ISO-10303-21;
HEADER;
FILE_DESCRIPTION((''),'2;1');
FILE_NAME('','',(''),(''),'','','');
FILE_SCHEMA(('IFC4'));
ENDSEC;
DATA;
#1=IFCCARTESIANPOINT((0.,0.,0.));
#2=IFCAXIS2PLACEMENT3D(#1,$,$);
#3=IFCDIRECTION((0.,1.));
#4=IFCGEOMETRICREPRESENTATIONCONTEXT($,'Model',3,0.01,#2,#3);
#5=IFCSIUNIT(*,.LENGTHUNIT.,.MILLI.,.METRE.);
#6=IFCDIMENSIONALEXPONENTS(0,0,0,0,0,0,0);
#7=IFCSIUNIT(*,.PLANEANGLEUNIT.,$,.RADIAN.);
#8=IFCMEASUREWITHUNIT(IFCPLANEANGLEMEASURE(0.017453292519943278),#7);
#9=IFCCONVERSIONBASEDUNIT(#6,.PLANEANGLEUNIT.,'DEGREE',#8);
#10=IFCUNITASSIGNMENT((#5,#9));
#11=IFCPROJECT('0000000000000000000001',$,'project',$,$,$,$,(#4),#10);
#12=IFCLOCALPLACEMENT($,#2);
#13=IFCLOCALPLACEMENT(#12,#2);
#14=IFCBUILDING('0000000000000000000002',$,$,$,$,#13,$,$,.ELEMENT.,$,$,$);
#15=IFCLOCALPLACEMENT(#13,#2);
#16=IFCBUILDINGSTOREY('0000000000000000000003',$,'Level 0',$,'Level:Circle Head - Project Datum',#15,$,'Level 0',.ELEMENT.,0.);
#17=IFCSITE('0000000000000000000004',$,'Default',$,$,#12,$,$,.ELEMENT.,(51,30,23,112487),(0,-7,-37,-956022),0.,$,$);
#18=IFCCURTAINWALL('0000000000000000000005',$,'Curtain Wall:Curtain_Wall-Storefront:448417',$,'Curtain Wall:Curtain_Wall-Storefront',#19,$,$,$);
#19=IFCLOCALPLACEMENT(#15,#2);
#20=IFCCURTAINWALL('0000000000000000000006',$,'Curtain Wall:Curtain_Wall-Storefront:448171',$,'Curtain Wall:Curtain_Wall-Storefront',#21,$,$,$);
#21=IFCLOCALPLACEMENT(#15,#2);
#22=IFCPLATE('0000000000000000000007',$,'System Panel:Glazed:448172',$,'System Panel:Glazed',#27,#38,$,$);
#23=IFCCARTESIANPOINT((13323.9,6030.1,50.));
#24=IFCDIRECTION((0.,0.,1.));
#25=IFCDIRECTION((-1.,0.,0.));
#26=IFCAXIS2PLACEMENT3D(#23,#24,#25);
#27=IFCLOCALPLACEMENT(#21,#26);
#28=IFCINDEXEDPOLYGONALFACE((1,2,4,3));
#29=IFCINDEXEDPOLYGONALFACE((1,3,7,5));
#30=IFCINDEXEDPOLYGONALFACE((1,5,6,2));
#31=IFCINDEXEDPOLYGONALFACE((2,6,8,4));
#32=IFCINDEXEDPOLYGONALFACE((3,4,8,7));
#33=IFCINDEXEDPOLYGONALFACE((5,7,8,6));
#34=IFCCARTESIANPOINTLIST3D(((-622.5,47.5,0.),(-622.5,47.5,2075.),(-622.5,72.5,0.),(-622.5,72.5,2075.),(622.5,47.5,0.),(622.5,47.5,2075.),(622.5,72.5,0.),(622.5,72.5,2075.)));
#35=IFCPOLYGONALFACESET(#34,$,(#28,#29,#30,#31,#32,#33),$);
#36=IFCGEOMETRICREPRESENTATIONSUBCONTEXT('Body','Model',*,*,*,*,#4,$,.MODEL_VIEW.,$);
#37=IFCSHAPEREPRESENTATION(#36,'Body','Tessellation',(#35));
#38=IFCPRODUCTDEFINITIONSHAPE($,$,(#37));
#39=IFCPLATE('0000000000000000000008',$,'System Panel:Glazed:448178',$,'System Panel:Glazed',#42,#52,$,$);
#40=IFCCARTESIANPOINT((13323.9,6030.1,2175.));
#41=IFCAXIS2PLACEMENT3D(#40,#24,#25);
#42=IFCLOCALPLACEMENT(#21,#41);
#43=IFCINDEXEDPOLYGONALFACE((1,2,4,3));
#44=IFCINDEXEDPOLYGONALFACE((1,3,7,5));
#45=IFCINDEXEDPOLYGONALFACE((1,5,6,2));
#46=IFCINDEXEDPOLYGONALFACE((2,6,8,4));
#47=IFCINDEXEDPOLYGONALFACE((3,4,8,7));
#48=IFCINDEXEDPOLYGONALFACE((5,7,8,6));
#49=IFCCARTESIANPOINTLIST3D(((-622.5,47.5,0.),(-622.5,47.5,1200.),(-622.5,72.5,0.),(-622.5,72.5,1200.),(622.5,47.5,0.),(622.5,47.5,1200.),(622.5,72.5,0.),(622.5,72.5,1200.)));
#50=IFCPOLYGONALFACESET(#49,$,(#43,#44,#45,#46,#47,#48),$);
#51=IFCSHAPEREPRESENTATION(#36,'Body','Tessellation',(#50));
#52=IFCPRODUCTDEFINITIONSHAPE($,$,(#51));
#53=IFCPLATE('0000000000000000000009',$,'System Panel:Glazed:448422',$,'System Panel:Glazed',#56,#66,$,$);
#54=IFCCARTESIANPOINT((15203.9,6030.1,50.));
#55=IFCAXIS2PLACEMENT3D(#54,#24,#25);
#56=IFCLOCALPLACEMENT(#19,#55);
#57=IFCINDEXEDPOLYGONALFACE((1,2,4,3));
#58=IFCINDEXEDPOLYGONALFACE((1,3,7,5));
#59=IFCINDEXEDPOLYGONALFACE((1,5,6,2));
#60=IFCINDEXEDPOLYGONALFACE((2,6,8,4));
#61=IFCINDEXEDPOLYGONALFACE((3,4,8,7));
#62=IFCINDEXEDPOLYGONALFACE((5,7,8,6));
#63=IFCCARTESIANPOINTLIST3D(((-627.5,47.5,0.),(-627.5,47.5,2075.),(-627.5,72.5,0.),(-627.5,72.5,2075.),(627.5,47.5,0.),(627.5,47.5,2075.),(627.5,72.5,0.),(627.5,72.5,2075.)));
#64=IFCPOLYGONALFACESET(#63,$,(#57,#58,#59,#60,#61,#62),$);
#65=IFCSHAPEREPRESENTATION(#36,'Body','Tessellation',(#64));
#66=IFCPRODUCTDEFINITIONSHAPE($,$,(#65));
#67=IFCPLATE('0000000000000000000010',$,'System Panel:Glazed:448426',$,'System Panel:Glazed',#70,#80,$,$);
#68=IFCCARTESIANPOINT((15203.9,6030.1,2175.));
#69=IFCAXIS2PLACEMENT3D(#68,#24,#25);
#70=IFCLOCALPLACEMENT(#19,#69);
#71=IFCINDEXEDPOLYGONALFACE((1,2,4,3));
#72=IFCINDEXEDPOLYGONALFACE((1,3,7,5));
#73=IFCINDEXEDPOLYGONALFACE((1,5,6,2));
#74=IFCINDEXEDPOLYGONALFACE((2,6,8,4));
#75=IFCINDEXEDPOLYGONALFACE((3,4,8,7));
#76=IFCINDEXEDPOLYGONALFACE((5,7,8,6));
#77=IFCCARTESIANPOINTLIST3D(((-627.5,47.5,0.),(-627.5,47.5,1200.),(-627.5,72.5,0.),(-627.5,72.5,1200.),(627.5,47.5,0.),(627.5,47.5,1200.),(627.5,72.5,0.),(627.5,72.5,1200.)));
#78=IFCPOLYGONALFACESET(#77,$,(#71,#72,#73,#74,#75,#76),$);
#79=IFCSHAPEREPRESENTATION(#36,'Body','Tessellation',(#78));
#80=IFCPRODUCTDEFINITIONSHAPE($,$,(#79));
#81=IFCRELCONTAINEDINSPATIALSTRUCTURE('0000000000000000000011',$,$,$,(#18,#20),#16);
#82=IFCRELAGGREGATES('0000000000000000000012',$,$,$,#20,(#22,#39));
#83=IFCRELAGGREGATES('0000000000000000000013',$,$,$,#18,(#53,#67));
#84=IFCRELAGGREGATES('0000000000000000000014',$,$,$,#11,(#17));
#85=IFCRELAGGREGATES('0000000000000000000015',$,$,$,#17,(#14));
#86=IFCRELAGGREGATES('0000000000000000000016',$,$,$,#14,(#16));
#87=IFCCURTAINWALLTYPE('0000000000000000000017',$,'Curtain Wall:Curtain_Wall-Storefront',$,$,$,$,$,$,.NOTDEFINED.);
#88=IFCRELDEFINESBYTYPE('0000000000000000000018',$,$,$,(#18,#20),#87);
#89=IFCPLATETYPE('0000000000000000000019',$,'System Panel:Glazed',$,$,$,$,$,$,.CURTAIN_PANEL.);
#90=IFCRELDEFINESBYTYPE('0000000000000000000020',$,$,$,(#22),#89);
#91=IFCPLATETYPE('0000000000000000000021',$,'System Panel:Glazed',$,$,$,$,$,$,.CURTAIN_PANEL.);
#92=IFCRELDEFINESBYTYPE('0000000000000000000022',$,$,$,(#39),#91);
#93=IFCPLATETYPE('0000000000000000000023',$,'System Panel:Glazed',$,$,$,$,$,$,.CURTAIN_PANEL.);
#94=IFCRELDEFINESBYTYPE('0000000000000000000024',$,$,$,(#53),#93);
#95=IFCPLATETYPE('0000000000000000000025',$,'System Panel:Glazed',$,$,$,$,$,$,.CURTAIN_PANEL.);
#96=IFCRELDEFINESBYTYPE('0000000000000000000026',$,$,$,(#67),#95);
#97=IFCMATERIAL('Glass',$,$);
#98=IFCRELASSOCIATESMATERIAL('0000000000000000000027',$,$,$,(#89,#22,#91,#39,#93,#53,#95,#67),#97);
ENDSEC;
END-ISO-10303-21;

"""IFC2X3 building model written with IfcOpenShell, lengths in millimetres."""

from ifc_helpers import new_model, entity, si_unit, converted_unit, direction, frame, origin, origin_2d_with_axis, place, context, subcontext, project, spatial, rectangle, extrude, source, transform, mapped, material, type_object, type_shapes, element, aggregate, save


model = new_model("IFC2X3")

# Units and contexts
model_context = context("Model", 3, precision=0.01, world=origin(), true_north=direction((0.0, 1.0)))
body_context = subcontext(model_context, "Body", "Model", "MODEL_VIEW")
ifc_project = project(units=[si_unit("LENGTHUNIT", "METRE", prefix="MILLI"), converted_unit("PLANEANGLEUNIT", "DEGREE", entity("IfcPlaneAngleMeasure", 0.017453292519943278), si_unit("PLANEANGLEUNIT", "RADIAN"), dimensions=[0, 0, 0, 0, 0, 0, 0])], contexts=[model_context])

# Site, building, storey
site_placement = place(None, origin())
site = spatial("IfcSite", under=ifc_project, at=site_placement, Name="Default", CompositionType="ELEMENT", RefLatitude=(51, 30, 23, 112487), RefLongitude=(0, -7, -37, -956022), RefElevation=0.0)
building_placement = place(site_placement, origin())
building = spatial("IfcBuilding", under=site, at=building_placement, CompositionType="ELEMENT")
storey_placement = place(building_placement, origin())
storey = spatial("IfcBuildingStorey", under=building, at=storey_placement, Name="Level 0", ObjectType="Level:Circle Head - Project Datum", LongName="Level 0", CompositionType="ELEMENT", Elevation=0.0)

# Curtain walls
curtain_wall_type = type_object("IfcCurtainWallType", Name="Curtain Wall:Curtain_Wall-Storefront", PredefinedType="NOTDEFINED")
curtain_wall_1_placement = place(storey_placement, origin())
curtain_wall_1 = element("IfcCurtainWall", 1, at=curtain_wall_1_placement, inside=storey, type_object=curtain_wall_type, Name="Curtain Wall:Curtain_Wall-Storefront:448417", ObjectType="Curtain Wall:Curtain_Wall-Storefront")
curtain_wall_2_placement = place(storey_placement, origin())
curtain_wall_2 = element("IfcCurtainWall", 2, at=curtain_wall_2_placement, inside=storey, type_object=curtain_wall_type, Name="Curtain Wall:Curtain_Wall-Storefront:448171", ObjectType="Curtain Wall:Curtain_Wall-Storefront")

# Plates
ifc_material_1 = material(Name="Glass")
plate_type_1 = type_object("IfcPlateType", Name="System Panel:Glazed", PredefinedType="CURTAIN_PANEL", material=ifc_material_1)
shared_shape_1 = source(origin(), body_context, "Body", "SweptSolid", [
    extrude(rectangle(XDim=25.0, YDim=1245.0, at=origin_2d_with_axis()), frame((0.0, 60.0, 0.0), z_axis=(0.0, 0.0, 1.0), x_axis=(0.0, 1.0, 0.0)), (0.0, 0.0, 1.0), 2075.0),
])
type_shapes(plate_type_1, [shared_shape_1])
plate_1_placement = place(curtain_wall_2_placement, frame((13323.9, 6030.1, 50.0), z_axis=(0.0, 0.0, 1.0), x_axis=(-1.0, 0.0, 0.0)))
plate_1 = element("IfcPlate", 3, at=plate_1_placement, type_object=plate_type_1, material=ifc_material_1, Name="System Panel:Glazed:448172", ObjectType="System Panel:Glazed", context=body_context, shape_type="MappedRepresentation", body=[
    mapped(shared_shape_1, transform((0.0, 0.0, 0.0), scale=1.0)),
])
plate_type_2 = type_object("IfcPlateType", Name="System Panel:Glazed", PredefinedType="CURTAIN_PANEL", material=ifc_material_1)
shared_shape_2 = source(origin(), body_context, "Body", "SweptSolid", [
    extrude(rectangle(XDim=25.0, YDim=1245.0, at=origin_2d_with_axis()), frame((0.0, 60.0, 0.0), z_axis=(0.0, 0.0, 1.0), x_axis=(0.0, 1.0, 0.0)), (0.0, 0.0, 1.0), 1200.0),
])
type_shapes(plate_type_2, [shared_shape_2])
plate_2_placement = place(curtain_wall_2_placement, frame((13323.9, 6030.1, 2175.0), z_axis=(0.0, 0.0, 1.0), x_axis=(-1.0, 0.0, 0.0)))
plate_2 = element("IfcPlate", 4, at=plate_2_placement, type_object=plate_type_2, material=ifc_material_1, Name="System Panel:Glazed:448178", ObjectType="System Panel:Glazed", context=body_context, shape_type="MappedRepresentation", body=[
    mapped(shared_shape_2, transform((0.0, 0.0, 0.0), scale=1.0)),
])
aggregate(curtain_wall_2, [plate_1, plate_2])
plate_type_3 = type_object("IfcPlateType", Name="System Panel:Glazed", PredefinedType="CURTAIN_PANEL", material=ifc_material_1)
shared_shape_3 = source(origin(), body_context, "Body", "SweptSolid", [
    extrude(rectangle(XDim=25.0, YDim=1255.0, at=origin_2d_with_axis()), frame((0.0, 60.0, 0.0), z_axis=(0.0, 0.0, 1.0), x_axis=(0.0, 1.0, 0.0)), (0.0, 0.0, 1.0), 2075.0),
])
type_shapes(plate_type_3, [shared_shape_3])
plate_3_placement = place(curtain_wall_1_placement, frame((15203.9, 6030.1, 50.0), z_axis=(0.0, 0.0, 1.0), x_axis=(-1.0, 0.0, 0.0)))
plate_3 = element("IfcPlate", 5, at=plate_3_placement, type_object=plate_type_3, material=ifc_material_1, Name="System Panel:Glazed:448422", ObjectType="System Panel:Glazed", context=body_context, shape_type="MappedRepresentation", body=[
    mapped(shared_shape_3, transform((0.0, 0.0, 0.0), scale=1.0)),
])
plate_type_4 = type_object("IfcPlateType", Name="System Panel:Glazed", PredefinedType="CURTAIN_PANEL", material=ifc_material_1)
shared_shape_4 = source(origin(), body_context, "Body", "SweptSolid", [
    extrude(rectangle(XDim=25.0, YDim=1255.0, at=origin_2d_with_axis()), frame((0.0, 60.0, 0.0), z_axis=(0.0, 0.0, 1.0), x_axis=(0.0, 1.0, 0.0)), (0.0, 0.0, 1.0), 1200.0),
])
type_shapes(plate_type_4, [shared_shape_4])
plate_4_placement = place(curtain_wall_1_placement, frame((15203.9, 6030.1, 2175.0), z_axis=(0.0, 0.0, 1.0), x_axis=(-1.0, 0.0, 0.0)))
plate_4 = element("IfcPlate", 6, at=plate_4_placement, type_object=plate_type_4, material=ifc_material_1, Name="System Panel:Glazed:448426", ObjectType="System Panel:Glazed", context=body_context, shape_type="MappedRepresentation", body=[
    mapped(shared_shape_4, transform((0.0, 0.0, 0.0), scale=1.0)),
])
aggregate(curtain_wall_1, [plate_3, plate_4])

save(model, "model.ifc")
